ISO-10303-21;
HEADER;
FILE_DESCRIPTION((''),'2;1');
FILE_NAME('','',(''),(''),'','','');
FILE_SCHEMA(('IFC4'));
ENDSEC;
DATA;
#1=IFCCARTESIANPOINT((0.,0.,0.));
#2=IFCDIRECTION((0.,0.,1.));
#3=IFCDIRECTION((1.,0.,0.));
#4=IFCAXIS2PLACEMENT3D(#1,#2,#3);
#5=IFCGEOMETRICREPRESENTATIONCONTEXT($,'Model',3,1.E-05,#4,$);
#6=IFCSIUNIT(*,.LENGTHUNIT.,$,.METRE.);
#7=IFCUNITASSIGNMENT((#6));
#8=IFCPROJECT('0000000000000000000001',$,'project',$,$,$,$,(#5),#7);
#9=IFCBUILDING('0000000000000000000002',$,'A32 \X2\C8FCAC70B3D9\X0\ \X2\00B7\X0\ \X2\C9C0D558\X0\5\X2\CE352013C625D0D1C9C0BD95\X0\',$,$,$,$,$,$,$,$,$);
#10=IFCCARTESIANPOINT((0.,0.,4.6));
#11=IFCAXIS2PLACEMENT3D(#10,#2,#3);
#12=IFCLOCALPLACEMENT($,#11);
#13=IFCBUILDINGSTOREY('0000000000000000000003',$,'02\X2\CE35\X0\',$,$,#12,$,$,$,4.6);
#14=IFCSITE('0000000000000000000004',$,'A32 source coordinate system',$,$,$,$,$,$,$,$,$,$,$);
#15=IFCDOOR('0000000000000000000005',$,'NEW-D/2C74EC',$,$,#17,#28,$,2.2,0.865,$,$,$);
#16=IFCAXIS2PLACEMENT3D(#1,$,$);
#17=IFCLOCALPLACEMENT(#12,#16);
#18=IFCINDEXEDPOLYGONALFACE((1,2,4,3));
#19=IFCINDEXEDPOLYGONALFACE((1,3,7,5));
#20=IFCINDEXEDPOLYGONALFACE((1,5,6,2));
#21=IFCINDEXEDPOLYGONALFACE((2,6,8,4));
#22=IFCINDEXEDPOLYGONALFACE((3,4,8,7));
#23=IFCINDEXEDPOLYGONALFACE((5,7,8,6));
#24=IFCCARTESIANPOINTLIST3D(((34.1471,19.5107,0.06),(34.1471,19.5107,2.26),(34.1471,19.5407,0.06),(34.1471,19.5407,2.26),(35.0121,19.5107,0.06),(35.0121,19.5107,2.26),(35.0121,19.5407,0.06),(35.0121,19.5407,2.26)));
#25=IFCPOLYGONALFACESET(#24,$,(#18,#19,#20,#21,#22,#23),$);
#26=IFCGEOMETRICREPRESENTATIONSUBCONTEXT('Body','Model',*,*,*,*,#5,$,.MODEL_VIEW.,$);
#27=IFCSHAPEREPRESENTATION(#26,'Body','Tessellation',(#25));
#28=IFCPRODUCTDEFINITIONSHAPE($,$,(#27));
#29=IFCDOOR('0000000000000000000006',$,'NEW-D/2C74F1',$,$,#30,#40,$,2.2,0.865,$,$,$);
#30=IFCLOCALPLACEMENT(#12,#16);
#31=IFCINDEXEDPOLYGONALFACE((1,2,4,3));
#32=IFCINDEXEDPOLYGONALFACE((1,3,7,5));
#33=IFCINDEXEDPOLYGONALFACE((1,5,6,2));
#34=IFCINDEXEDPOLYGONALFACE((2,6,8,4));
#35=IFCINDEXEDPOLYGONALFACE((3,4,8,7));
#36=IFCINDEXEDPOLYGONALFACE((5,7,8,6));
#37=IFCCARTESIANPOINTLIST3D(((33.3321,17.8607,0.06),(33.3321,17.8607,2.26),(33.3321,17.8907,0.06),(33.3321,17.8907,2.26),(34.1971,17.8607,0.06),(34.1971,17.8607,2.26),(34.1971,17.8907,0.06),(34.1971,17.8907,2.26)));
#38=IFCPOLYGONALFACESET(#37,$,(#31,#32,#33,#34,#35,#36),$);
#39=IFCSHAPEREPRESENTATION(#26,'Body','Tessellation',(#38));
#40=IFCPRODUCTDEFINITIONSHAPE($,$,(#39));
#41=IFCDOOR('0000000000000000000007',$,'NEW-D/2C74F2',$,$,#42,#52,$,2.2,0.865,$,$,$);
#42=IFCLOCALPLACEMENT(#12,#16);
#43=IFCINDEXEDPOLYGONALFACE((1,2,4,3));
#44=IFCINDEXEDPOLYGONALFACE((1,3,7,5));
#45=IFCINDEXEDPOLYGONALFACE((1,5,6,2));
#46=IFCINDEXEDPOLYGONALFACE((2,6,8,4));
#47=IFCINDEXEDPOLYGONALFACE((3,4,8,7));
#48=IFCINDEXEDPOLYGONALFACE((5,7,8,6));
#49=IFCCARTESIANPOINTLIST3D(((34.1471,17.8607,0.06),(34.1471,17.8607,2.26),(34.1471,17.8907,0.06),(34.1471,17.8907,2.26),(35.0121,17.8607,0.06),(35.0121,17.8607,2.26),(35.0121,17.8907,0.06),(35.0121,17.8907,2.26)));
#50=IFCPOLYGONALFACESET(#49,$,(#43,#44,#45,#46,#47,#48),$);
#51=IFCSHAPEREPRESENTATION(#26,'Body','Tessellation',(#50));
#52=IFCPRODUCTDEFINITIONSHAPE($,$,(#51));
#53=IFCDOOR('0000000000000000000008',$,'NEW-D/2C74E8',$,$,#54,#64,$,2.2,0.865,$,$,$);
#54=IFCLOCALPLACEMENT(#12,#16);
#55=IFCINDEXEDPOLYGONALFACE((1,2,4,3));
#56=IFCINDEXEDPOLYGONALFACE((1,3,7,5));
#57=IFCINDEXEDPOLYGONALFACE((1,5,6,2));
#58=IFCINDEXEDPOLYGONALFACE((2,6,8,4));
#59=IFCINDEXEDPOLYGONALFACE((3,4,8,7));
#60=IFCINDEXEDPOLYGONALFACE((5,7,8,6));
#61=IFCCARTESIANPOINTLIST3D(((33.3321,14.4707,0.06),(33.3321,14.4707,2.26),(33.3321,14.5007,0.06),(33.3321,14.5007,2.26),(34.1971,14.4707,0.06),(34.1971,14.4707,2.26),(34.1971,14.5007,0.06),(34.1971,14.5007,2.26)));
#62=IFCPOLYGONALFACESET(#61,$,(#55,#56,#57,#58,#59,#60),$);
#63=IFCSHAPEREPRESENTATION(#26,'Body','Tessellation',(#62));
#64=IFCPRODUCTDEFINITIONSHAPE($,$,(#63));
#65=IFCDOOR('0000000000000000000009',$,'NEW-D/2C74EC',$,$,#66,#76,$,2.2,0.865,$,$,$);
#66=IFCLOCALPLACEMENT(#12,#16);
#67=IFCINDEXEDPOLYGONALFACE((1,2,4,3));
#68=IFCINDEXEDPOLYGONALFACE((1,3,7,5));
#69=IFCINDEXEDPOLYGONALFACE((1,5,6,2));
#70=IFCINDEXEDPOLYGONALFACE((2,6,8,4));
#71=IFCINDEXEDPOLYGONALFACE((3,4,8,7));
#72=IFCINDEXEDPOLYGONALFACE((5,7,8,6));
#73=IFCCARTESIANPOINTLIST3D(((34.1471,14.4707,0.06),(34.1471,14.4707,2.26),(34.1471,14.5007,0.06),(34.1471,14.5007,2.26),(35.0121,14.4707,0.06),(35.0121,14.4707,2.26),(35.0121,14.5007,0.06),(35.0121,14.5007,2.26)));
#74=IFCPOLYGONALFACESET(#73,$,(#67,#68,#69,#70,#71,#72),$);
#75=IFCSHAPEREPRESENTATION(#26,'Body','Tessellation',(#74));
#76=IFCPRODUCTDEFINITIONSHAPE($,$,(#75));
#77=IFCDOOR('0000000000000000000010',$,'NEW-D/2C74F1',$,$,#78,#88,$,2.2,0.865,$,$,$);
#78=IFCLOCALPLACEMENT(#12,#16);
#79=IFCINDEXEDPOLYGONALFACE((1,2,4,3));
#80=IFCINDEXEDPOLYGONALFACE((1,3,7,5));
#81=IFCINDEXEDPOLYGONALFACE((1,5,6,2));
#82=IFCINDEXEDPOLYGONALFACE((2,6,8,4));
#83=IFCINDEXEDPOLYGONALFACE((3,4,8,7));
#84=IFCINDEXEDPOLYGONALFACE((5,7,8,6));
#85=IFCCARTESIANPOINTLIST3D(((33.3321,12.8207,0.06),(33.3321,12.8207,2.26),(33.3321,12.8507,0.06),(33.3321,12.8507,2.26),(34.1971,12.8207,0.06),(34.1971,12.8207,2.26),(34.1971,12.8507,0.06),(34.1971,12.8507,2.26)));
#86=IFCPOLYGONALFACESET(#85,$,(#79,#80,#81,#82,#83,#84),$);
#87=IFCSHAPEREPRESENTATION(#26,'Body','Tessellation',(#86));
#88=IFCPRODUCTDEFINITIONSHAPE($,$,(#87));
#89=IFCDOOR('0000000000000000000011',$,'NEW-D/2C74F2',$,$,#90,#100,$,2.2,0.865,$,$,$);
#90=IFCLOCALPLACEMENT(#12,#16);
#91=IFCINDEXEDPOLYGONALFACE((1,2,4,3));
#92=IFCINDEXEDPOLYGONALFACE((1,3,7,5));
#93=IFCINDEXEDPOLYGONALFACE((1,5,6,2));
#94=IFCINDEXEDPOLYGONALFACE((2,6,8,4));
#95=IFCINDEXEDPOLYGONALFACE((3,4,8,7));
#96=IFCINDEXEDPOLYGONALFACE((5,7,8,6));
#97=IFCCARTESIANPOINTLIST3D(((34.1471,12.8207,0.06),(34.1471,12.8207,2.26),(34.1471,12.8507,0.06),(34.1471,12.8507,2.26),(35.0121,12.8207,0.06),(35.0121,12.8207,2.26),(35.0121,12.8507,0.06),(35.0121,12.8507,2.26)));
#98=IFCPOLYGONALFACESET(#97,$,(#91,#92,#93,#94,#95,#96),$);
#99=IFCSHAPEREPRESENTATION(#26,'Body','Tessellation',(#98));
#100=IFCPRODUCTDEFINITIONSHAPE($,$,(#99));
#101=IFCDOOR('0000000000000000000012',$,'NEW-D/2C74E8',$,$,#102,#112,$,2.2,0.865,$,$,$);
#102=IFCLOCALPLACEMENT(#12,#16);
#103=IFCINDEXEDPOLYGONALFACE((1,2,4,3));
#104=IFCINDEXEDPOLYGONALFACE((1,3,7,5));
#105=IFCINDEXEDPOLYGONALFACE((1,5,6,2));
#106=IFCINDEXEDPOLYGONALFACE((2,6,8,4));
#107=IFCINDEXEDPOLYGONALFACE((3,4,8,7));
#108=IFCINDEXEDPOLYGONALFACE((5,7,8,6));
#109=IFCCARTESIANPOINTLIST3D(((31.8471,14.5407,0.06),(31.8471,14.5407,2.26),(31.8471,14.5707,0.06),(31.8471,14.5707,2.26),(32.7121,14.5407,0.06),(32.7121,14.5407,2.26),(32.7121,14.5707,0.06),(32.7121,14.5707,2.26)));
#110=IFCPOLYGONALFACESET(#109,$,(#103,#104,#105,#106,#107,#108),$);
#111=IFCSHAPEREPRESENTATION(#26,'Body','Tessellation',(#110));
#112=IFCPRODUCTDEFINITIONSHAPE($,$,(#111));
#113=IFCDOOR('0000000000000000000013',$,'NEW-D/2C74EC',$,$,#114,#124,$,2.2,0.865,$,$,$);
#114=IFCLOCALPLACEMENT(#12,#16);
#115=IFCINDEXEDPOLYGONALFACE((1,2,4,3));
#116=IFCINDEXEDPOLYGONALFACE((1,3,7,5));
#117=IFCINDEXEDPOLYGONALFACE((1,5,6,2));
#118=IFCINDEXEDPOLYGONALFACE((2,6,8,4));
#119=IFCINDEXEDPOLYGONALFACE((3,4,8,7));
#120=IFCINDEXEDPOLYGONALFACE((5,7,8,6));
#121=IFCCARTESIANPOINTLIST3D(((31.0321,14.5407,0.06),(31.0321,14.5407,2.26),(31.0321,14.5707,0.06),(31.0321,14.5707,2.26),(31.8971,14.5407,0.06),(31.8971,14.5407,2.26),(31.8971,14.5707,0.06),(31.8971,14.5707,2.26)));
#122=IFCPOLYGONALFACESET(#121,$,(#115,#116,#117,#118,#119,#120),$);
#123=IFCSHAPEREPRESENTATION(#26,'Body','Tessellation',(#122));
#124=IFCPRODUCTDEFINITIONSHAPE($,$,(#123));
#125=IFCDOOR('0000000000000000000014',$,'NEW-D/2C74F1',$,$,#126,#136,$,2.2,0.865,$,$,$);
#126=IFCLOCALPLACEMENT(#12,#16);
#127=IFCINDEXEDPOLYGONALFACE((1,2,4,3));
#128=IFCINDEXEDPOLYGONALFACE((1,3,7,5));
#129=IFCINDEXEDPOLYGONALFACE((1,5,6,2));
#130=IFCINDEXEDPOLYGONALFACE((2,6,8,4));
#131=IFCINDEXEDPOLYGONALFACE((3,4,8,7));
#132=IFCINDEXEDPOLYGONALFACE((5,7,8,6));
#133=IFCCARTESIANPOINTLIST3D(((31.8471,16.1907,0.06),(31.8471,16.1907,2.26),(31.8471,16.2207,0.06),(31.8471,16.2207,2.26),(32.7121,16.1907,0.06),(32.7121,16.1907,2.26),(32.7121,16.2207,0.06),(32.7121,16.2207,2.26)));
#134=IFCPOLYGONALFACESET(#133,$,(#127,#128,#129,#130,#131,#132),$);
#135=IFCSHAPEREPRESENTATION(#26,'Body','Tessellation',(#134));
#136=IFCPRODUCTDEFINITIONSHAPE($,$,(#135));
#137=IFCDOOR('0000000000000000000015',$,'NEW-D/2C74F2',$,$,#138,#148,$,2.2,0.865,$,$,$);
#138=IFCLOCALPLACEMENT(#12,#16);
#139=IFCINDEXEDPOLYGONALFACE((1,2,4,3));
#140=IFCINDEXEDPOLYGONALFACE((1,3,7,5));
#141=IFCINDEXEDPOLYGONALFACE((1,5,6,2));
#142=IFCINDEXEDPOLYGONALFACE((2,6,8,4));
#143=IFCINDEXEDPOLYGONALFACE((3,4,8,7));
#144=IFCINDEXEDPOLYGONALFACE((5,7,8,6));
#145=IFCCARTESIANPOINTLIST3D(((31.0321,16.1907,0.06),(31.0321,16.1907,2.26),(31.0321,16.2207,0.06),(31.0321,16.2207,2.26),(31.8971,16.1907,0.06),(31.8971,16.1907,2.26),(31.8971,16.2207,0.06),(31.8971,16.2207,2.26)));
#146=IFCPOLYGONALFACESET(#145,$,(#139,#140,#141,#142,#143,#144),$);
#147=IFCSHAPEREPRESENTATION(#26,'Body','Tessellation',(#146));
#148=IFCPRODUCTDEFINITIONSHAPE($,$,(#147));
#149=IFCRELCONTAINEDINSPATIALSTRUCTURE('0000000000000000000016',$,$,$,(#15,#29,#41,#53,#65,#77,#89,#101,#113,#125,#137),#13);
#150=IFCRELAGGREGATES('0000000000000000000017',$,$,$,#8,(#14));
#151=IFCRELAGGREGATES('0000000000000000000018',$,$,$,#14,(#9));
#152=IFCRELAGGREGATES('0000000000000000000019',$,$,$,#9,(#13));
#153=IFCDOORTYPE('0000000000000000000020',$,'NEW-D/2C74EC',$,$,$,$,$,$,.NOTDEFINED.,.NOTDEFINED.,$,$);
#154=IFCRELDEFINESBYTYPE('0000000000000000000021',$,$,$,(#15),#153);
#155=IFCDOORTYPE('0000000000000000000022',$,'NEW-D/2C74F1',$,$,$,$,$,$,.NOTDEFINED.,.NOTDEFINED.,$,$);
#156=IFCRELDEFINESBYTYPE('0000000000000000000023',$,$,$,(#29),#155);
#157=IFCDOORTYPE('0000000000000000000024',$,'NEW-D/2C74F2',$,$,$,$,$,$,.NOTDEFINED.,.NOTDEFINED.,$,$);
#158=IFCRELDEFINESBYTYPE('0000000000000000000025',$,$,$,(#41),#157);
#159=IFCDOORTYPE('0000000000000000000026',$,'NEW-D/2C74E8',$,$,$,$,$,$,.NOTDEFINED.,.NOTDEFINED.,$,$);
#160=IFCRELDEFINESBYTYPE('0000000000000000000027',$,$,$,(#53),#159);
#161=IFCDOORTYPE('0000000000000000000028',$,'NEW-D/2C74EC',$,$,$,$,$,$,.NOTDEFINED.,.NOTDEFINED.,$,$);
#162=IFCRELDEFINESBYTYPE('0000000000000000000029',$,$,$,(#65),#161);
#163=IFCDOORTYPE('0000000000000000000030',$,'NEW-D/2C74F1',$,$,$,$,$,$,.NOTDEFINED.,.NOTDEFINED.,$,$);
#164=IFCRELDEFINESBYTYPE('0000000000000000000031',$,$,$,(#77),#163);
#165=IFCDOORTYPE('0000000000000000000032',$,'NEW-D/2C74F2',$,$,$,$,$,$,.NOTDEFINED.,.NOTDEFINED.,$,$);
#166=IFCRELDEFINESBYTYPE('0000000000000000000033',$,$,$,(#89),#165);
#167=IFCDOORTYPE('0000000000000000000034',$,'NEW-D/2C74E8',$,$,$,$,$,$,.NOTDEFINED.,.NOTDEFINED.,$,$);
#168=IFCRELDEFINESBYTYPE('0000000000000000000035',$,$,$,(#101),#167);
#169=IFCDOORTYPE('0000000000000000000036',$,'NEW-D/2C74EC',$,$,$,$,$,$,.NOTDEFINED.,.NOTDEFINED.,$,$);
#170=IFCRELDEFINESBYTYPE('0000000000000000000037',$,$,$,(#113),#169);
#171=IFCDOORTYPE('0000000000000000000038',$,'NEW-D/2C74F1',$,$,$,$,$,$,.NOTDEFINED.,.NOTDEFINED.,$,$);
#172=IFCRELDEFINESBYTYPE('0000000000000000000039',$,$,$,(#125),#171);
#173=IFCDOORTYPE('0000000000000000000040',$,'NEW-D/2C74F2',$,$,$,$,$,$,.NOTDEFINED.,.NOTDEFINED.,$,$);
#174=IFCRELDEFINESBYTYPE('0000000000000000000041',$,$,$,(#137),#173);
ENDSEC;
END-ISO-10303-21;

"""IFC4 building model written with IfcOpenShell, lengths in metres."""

from ifc_helpers import new_model, si_unit, frame, origin, origin_with_axes, place, context, subcontext, project, spatial, polyline, outline, extrude, source, transform, mapped, type_object, type_shapes, element, save


model = new_model("IFC4")

# Units and contexts
model_context = context("Model", 3, precision=1e-05, world=origin_with_axes())
body_context = subcontext(model_context, "Body", "Model", "MODEL_VIEW")
ifc_project = project(units=[si_unit("LENGTHUNIT", "METRE")], contexts=[model_context])

# Site, building, storey
storey_placement = place(None, frame((0.0, 0.0, 4.6), z_axis=(0.0, 0.0, 1.0), x_axis=(1.0, 0.0, 0.0)))
site = spatial("IfcSite", under=ifc_project, Name="A32 source coordinate system")
building = spatial("IfcBuilding", under=site, Name="A32 주거동 · 지하5층–옥탑지붕")
storey = spatial("IfcBuildingStorey", under=building, at=storey_placement, Name="02층", Elevation=4.6)

# Doors
door_type_1 = type_object("IfcDoorType", Name="NEW-D/2C74EC", OperationType="NOTDEFINED", PredefinedType="NOTDEFINED")
shared_shape_1 = source(origin(), body_context, "Body", "SweptSolid", [
    extrude(outline(polyline([(35.0121, 19.5407), (35.0121, 19.5107), (34.1471, 19.5107), (34.1471, 19.5407), (35.0121, 19.5407)])), frame((0.0, 0.0, 0.06)), (0.0, 0.0, 1.0), 2.2),
])
type_shapes(door_type_1, [shared_shape_1])
door_1_placement = place(storey_placement, origin_with_axes())
element("IfcDoor", 1, at=door_1_placement, inside=storey, type_object=door_type_1, Name="NEW-D/2C74EC", OverallHeight=2.2, OverallWidth=0.865, context=body_context, shape_type="MappedRepresentation", body=[
    mapped(shared_shape_1, transform((0.0, 0.0, 0.0), scale=1.0)),
])
door_type_2 = type_object("IfcDoorType", Name="NEW-D/2C74F1", OperationType="NOTDEFINED", PredefinedType="NOTDEFINED")
shared_shape_2 = source(origin(), body_context, "Body", "SweptSolid", [
    extrude(outline(polyline([(33.3321, 17.8607), (33.3321, 17.8907), (34.1971, 17.8907), (34.1971, 17.8607), (33.3321, 17.8607)])), frame((0.0, 0.0, 0.06)), (0.0, 0.0, 1.0), 2.2),
])
type_shapes(door_type_2, [shared_shape_2])
door_2_placement = place(storey_placement, origin_with_axes())
element("IfcDoor", 2, at=door_2_placement, inside=storey, type_object=door_type_2, Name="NEW-D/2C74F1", OverallHeight=2.2, OverallWidth=0.865, context=body_context, shape_type="MappedRepresentation", body=[
    mapped(shared_shape_2, transform((0.0, 0.0, 0.0), scale=1.0)),
])
door_type_3 = type_object("IfcDoorType", Name="NEW-D/2C74F2", OperationType="NOTDEFINED", PredefinedType="NOTDEFINED")
shared_shape_3 = source(origin(), body_context, "Body", "SweptSolid", [
    extrude(outline(polyline([(34.1471, 17.8907), (35.0121, 17.8907), (35.0121, 17.8607), (34.1471, 17.8607), (34.1471, 17.8907)])), frame((0.0, 0.0, 0.06)), (0.0, 0.0, 1.0), 2.2),
])
type_shapes(door_type_3, [shared_shape_3])
door_3_placement = place(storey_placement, origin_with_axes())
element("IfcDoor", 3, at=door_3_placement, inside=storey, type_object=door_type_3, Name="NEW-D/2C74F2", OverallHeight=2.2, OverallWidth=0.865, context=body_context, shape_type="MappedRepresentation", body=[
    mapped(shared_shape_3, transform((0.0, 0.0, 0.0), scale=1.0)),
])
door_type_4 = type_object("IfcDoorType", Name="NEW-D/2C74E8", OperationType="NOTDEFINED", PredefinedType="NOTDEFINED")
shared_shape_4 = source(origin(), body_context, "Body", "SweptSolid", [
    extrude(outline(polyline([(34.1971, 14.4707), (33.3321, 14.4707), (33.3321, 14.5007), (34.1971, 14.5007), (34.1971, 14.4707)])), frame((0.0, 0.0, 0.06)), (0.0, 0.0, 1.0), 2.2),
])
type_shapes(door_type_4, [shared_shape_4])
door_4_placement = place(storey_placement, origin_with_axes())
element("IfcDoor", 4, at=door_4_placement, inside=storey, type_object=door_type_4, Name="NEW-D/2C74E8", OverallHeight=2.2, OverallWidth=0.865, context=body_context, shape_type="MappedRepresentation", body=[
    mapped(shared_shape_4, transform((0.0, 0.0, 0.0), scale=1.0)),
])
door_type_5 = type_object("IfcDoorType", Name="NEW-D/2C74EC", OperationType="NOTDEFINED", PredefinedType="NOTDEFINED")
shared_shape_5 = source(origin(), body_context, "Body", "SweptSolid", [
    extrude(outline(polyline([(35.0121, 14.5007), (35.0121, 14.4707), (34.1471, 14.4707), (34.1471, 14.5007), (35.0121, 14.5007)])), frame((0.0, 0.0, 0.06)), (0.0, 0.0, 1.0), 2.2),
])
type_shapes(door_type_5, [shared_shape_5])
door_5_placement = place(storey_placement, origin_with_axes())
element("IfcDoor", 5, at=door_5_placement, inside=storey, type_object=door_type_5, Name="NEW-D/2C74EC", OverallHeight=2.2, OverallWidth=0.865, context=body_context, shape_type="MappedRepresentation", body=[
    mapped(shared_shape_5, transform((0.0, 0.0, 0.0), scale=1.0)),
])
door_type_6 = type_object("IfcDoorType", Name="NEW-D/2C74F1", OperationType="NOTDEFINED", PredefinedType="NOTDEFINED")
shared_shape_6 = source(origin(), body_context, "Body", "SweptSolid", [
    extrude(outline(polyline([(33.3321, 12.8207), (33.3321, 12.8507), (34.1971, 12.8507), (34.1971, 12.8207), (33.3321, 12.8207)])), frame((0.0, 0.0, 0.06)), (0.0, 0.0, 1.0), 2.2),
])
type_shapes(door_type_6, [shared_shape_6])
door_6_placement = place(storey_placement, origin_with_axes())
element("IfcDoor", 6, at=door_6_placement, inside=storey, type_object=door_type_6, Name="NEW-D/2C74F1", OverallHeight=2.2, OverallWidth=0.865, context=body_context, shape_type="MappedRepresentation", body=[
    mapped(shared_shape_6, transform((0.0, 0.0, 0.0), scale=1.0)),
])
door_type_7 = type_object("IfcDoorType", Name="NEW-D/2C74F2", OperationType="NOTDEFINED", PredefinedType="NOTDEFINED")
shared_shape_7 = source(origin(), body_context, "Body", "SweptSolid", [
    extrude(outline(polyline([(34.1471, 12.8507), (35.0121, 12.8507), (35.0121, 12.8207), (34.1471, 12.8207), (34.1471, 12.8507)])), frame((0.0, 0.0, 0.06)), (0.0, 0.0, 1.0), 2.2),
])
type_shapes(door_type_7, [shared_shape_7])
door_7_placement = place(storey_placement, origin_with_axes())
element("IfcDoor", 7, at=door_7_placement, inside=storey, type_object=door_type_7, Name="NEW-D/2C74F2", OverallHeight=2.2, OverallWidth=0.865, context=body_context, shape_type="MappedRepresentation", body=[
    mapped(shared_shape_7, transform((0.0, 0.0, 0.0), scale=1.0)),
])
door_type_8 = type_object("IfcDoorType", Name="NEW-D/2C74E8", OperationType="NOTDEFINED", PredefinedType="NOTDEFINED")
shared_shape_8 = source(origin(), body_context, "Body", "SweptSolid", [
    extrude(outline(polyline([(31.8471, 14.5707), (32.7121, 14.5707), (32.7121, 14.5407), (31.8471, 14.5407), (31.8471, 14.5707)])), frame((0.0, 0.0, 0.06)), (0.0, 0.0, 1.0), 2.2),
])
type_shapes(door_type_8, [shared_shape_8])
door_8_placement = place(storey_placement, origin_with_axes())
element("IfcDoor", 8, at=door_8_placement, inside=storey, type_object=door_type_8, Name="NEW-D/2C74E8", OverallHeight=2.2, OverallWidth=0.865, context=body_context, shape_type="MappedRepresentation", body=[
    mapped(shared_shape_8, transform((0.0, 0.0, 0.0), scale=1.0)),
])
door_type_9 = type_object("IfcDoorType", Name="NEW-D/2C74EC", OperationType="NOTDEFINED", PredefinedType="NOTDEFINED")
shared_shape_9 = source(origin(), body_context, "Body", "SweptSolid", [
    extrude(outline(polyline([(31.0321, 14.5407), (31.0321, 14.5707), (31.8971, 14.5707), (31.8971, 14.5407), (31.0321, 14.5407)])), frame((0.0, 0.0, 0.06)), (0.0, 0.0, 1.0), 2.2),
])
type_shapes(door_type_9, [shared_shape_9])
door_9_placement = place(storey_placement, origin_with_axes())
element("IfcDoor", 9, at=door_9_placement, inside=storey, type_object=door_type_9, Name="NEW-D/2C74EC", OverallHeight=2.2, OverallWidth=0.865, context=body_context, shape_type="MappedRepresentation", body=[
    mapped(shared_shape_9, transform((0.0, 0.0, 0.0), scale=1.0)),
])
door_type_10 = type_object("IfcDoorType", Name="NEW-D/2C74F1", OperationType="NOTDEFINED", PredefinedType="NOTDEFINED")
shared_shape_10 = source(origin(), body_context, "Body", "SweptSolid", [
    extrude(outline(polyline([(32.7121, 16.2207), (32.7121, 16.1907), (31.8471, 16.1907), (31.8471, 16.2207), (32.7121, 16.2207)])), frame((0.0, 0.0, 0.06)), (0.0, 0.0, 1.0), 2.2),
])
type_shapes(door_type_10, [shared_shape_10])
door_10_placement = place(storey_placement, origin_with_axes())
element("IfcDoor", 10, at=door_10_placement, inside=storey, type_object=door_type_10, Name="NEW-D/2C74F1", OverallHeight=2.2, OverallWidth=0.865, context=body_context, shape_type="MappedRepresentation", body=[
    mapped(shared_shape_10, transform((0.0, 0.0, 0.0), scale=1.0)),
])
door_type_11 = type_object("IfcDoorType", Name="NEW-D/2C74F2", OperationType="NOTDEFINED", PredefinedType="NOTDEFINED")
shared_shape_11 = source(origin(), body_context, "Body", "SweptSolid", [
    extrude(outline(polyline([(31.8971, 16.1907), (31.0321, 16.1907), (31.0321, 16.2207), (31.8971, 16.2207), (31.8971, 16.1907)])), frame((0.0, 0.0, 0.06)), (0.0, 0.0, 1.0), 2.2),
])
type_shapes(door_type_11, [shared_shape_11])
door_11_placement = place(storey_placement, origin_with_axes())
element("IfcDoor", 11, at=door_11_placement, inside=storey, type_object=door_type_11, Name="NEW-D/2C74F2", OverallHeight=2.2, OverallWidth=0.865, context=body_context, shape_type="MappedRepresentation", body=[
    mapped(shared_shape_11, transform((0.0, 0.0, 0.0), scale=1.0)),
])

save(model, "model.ifc")
